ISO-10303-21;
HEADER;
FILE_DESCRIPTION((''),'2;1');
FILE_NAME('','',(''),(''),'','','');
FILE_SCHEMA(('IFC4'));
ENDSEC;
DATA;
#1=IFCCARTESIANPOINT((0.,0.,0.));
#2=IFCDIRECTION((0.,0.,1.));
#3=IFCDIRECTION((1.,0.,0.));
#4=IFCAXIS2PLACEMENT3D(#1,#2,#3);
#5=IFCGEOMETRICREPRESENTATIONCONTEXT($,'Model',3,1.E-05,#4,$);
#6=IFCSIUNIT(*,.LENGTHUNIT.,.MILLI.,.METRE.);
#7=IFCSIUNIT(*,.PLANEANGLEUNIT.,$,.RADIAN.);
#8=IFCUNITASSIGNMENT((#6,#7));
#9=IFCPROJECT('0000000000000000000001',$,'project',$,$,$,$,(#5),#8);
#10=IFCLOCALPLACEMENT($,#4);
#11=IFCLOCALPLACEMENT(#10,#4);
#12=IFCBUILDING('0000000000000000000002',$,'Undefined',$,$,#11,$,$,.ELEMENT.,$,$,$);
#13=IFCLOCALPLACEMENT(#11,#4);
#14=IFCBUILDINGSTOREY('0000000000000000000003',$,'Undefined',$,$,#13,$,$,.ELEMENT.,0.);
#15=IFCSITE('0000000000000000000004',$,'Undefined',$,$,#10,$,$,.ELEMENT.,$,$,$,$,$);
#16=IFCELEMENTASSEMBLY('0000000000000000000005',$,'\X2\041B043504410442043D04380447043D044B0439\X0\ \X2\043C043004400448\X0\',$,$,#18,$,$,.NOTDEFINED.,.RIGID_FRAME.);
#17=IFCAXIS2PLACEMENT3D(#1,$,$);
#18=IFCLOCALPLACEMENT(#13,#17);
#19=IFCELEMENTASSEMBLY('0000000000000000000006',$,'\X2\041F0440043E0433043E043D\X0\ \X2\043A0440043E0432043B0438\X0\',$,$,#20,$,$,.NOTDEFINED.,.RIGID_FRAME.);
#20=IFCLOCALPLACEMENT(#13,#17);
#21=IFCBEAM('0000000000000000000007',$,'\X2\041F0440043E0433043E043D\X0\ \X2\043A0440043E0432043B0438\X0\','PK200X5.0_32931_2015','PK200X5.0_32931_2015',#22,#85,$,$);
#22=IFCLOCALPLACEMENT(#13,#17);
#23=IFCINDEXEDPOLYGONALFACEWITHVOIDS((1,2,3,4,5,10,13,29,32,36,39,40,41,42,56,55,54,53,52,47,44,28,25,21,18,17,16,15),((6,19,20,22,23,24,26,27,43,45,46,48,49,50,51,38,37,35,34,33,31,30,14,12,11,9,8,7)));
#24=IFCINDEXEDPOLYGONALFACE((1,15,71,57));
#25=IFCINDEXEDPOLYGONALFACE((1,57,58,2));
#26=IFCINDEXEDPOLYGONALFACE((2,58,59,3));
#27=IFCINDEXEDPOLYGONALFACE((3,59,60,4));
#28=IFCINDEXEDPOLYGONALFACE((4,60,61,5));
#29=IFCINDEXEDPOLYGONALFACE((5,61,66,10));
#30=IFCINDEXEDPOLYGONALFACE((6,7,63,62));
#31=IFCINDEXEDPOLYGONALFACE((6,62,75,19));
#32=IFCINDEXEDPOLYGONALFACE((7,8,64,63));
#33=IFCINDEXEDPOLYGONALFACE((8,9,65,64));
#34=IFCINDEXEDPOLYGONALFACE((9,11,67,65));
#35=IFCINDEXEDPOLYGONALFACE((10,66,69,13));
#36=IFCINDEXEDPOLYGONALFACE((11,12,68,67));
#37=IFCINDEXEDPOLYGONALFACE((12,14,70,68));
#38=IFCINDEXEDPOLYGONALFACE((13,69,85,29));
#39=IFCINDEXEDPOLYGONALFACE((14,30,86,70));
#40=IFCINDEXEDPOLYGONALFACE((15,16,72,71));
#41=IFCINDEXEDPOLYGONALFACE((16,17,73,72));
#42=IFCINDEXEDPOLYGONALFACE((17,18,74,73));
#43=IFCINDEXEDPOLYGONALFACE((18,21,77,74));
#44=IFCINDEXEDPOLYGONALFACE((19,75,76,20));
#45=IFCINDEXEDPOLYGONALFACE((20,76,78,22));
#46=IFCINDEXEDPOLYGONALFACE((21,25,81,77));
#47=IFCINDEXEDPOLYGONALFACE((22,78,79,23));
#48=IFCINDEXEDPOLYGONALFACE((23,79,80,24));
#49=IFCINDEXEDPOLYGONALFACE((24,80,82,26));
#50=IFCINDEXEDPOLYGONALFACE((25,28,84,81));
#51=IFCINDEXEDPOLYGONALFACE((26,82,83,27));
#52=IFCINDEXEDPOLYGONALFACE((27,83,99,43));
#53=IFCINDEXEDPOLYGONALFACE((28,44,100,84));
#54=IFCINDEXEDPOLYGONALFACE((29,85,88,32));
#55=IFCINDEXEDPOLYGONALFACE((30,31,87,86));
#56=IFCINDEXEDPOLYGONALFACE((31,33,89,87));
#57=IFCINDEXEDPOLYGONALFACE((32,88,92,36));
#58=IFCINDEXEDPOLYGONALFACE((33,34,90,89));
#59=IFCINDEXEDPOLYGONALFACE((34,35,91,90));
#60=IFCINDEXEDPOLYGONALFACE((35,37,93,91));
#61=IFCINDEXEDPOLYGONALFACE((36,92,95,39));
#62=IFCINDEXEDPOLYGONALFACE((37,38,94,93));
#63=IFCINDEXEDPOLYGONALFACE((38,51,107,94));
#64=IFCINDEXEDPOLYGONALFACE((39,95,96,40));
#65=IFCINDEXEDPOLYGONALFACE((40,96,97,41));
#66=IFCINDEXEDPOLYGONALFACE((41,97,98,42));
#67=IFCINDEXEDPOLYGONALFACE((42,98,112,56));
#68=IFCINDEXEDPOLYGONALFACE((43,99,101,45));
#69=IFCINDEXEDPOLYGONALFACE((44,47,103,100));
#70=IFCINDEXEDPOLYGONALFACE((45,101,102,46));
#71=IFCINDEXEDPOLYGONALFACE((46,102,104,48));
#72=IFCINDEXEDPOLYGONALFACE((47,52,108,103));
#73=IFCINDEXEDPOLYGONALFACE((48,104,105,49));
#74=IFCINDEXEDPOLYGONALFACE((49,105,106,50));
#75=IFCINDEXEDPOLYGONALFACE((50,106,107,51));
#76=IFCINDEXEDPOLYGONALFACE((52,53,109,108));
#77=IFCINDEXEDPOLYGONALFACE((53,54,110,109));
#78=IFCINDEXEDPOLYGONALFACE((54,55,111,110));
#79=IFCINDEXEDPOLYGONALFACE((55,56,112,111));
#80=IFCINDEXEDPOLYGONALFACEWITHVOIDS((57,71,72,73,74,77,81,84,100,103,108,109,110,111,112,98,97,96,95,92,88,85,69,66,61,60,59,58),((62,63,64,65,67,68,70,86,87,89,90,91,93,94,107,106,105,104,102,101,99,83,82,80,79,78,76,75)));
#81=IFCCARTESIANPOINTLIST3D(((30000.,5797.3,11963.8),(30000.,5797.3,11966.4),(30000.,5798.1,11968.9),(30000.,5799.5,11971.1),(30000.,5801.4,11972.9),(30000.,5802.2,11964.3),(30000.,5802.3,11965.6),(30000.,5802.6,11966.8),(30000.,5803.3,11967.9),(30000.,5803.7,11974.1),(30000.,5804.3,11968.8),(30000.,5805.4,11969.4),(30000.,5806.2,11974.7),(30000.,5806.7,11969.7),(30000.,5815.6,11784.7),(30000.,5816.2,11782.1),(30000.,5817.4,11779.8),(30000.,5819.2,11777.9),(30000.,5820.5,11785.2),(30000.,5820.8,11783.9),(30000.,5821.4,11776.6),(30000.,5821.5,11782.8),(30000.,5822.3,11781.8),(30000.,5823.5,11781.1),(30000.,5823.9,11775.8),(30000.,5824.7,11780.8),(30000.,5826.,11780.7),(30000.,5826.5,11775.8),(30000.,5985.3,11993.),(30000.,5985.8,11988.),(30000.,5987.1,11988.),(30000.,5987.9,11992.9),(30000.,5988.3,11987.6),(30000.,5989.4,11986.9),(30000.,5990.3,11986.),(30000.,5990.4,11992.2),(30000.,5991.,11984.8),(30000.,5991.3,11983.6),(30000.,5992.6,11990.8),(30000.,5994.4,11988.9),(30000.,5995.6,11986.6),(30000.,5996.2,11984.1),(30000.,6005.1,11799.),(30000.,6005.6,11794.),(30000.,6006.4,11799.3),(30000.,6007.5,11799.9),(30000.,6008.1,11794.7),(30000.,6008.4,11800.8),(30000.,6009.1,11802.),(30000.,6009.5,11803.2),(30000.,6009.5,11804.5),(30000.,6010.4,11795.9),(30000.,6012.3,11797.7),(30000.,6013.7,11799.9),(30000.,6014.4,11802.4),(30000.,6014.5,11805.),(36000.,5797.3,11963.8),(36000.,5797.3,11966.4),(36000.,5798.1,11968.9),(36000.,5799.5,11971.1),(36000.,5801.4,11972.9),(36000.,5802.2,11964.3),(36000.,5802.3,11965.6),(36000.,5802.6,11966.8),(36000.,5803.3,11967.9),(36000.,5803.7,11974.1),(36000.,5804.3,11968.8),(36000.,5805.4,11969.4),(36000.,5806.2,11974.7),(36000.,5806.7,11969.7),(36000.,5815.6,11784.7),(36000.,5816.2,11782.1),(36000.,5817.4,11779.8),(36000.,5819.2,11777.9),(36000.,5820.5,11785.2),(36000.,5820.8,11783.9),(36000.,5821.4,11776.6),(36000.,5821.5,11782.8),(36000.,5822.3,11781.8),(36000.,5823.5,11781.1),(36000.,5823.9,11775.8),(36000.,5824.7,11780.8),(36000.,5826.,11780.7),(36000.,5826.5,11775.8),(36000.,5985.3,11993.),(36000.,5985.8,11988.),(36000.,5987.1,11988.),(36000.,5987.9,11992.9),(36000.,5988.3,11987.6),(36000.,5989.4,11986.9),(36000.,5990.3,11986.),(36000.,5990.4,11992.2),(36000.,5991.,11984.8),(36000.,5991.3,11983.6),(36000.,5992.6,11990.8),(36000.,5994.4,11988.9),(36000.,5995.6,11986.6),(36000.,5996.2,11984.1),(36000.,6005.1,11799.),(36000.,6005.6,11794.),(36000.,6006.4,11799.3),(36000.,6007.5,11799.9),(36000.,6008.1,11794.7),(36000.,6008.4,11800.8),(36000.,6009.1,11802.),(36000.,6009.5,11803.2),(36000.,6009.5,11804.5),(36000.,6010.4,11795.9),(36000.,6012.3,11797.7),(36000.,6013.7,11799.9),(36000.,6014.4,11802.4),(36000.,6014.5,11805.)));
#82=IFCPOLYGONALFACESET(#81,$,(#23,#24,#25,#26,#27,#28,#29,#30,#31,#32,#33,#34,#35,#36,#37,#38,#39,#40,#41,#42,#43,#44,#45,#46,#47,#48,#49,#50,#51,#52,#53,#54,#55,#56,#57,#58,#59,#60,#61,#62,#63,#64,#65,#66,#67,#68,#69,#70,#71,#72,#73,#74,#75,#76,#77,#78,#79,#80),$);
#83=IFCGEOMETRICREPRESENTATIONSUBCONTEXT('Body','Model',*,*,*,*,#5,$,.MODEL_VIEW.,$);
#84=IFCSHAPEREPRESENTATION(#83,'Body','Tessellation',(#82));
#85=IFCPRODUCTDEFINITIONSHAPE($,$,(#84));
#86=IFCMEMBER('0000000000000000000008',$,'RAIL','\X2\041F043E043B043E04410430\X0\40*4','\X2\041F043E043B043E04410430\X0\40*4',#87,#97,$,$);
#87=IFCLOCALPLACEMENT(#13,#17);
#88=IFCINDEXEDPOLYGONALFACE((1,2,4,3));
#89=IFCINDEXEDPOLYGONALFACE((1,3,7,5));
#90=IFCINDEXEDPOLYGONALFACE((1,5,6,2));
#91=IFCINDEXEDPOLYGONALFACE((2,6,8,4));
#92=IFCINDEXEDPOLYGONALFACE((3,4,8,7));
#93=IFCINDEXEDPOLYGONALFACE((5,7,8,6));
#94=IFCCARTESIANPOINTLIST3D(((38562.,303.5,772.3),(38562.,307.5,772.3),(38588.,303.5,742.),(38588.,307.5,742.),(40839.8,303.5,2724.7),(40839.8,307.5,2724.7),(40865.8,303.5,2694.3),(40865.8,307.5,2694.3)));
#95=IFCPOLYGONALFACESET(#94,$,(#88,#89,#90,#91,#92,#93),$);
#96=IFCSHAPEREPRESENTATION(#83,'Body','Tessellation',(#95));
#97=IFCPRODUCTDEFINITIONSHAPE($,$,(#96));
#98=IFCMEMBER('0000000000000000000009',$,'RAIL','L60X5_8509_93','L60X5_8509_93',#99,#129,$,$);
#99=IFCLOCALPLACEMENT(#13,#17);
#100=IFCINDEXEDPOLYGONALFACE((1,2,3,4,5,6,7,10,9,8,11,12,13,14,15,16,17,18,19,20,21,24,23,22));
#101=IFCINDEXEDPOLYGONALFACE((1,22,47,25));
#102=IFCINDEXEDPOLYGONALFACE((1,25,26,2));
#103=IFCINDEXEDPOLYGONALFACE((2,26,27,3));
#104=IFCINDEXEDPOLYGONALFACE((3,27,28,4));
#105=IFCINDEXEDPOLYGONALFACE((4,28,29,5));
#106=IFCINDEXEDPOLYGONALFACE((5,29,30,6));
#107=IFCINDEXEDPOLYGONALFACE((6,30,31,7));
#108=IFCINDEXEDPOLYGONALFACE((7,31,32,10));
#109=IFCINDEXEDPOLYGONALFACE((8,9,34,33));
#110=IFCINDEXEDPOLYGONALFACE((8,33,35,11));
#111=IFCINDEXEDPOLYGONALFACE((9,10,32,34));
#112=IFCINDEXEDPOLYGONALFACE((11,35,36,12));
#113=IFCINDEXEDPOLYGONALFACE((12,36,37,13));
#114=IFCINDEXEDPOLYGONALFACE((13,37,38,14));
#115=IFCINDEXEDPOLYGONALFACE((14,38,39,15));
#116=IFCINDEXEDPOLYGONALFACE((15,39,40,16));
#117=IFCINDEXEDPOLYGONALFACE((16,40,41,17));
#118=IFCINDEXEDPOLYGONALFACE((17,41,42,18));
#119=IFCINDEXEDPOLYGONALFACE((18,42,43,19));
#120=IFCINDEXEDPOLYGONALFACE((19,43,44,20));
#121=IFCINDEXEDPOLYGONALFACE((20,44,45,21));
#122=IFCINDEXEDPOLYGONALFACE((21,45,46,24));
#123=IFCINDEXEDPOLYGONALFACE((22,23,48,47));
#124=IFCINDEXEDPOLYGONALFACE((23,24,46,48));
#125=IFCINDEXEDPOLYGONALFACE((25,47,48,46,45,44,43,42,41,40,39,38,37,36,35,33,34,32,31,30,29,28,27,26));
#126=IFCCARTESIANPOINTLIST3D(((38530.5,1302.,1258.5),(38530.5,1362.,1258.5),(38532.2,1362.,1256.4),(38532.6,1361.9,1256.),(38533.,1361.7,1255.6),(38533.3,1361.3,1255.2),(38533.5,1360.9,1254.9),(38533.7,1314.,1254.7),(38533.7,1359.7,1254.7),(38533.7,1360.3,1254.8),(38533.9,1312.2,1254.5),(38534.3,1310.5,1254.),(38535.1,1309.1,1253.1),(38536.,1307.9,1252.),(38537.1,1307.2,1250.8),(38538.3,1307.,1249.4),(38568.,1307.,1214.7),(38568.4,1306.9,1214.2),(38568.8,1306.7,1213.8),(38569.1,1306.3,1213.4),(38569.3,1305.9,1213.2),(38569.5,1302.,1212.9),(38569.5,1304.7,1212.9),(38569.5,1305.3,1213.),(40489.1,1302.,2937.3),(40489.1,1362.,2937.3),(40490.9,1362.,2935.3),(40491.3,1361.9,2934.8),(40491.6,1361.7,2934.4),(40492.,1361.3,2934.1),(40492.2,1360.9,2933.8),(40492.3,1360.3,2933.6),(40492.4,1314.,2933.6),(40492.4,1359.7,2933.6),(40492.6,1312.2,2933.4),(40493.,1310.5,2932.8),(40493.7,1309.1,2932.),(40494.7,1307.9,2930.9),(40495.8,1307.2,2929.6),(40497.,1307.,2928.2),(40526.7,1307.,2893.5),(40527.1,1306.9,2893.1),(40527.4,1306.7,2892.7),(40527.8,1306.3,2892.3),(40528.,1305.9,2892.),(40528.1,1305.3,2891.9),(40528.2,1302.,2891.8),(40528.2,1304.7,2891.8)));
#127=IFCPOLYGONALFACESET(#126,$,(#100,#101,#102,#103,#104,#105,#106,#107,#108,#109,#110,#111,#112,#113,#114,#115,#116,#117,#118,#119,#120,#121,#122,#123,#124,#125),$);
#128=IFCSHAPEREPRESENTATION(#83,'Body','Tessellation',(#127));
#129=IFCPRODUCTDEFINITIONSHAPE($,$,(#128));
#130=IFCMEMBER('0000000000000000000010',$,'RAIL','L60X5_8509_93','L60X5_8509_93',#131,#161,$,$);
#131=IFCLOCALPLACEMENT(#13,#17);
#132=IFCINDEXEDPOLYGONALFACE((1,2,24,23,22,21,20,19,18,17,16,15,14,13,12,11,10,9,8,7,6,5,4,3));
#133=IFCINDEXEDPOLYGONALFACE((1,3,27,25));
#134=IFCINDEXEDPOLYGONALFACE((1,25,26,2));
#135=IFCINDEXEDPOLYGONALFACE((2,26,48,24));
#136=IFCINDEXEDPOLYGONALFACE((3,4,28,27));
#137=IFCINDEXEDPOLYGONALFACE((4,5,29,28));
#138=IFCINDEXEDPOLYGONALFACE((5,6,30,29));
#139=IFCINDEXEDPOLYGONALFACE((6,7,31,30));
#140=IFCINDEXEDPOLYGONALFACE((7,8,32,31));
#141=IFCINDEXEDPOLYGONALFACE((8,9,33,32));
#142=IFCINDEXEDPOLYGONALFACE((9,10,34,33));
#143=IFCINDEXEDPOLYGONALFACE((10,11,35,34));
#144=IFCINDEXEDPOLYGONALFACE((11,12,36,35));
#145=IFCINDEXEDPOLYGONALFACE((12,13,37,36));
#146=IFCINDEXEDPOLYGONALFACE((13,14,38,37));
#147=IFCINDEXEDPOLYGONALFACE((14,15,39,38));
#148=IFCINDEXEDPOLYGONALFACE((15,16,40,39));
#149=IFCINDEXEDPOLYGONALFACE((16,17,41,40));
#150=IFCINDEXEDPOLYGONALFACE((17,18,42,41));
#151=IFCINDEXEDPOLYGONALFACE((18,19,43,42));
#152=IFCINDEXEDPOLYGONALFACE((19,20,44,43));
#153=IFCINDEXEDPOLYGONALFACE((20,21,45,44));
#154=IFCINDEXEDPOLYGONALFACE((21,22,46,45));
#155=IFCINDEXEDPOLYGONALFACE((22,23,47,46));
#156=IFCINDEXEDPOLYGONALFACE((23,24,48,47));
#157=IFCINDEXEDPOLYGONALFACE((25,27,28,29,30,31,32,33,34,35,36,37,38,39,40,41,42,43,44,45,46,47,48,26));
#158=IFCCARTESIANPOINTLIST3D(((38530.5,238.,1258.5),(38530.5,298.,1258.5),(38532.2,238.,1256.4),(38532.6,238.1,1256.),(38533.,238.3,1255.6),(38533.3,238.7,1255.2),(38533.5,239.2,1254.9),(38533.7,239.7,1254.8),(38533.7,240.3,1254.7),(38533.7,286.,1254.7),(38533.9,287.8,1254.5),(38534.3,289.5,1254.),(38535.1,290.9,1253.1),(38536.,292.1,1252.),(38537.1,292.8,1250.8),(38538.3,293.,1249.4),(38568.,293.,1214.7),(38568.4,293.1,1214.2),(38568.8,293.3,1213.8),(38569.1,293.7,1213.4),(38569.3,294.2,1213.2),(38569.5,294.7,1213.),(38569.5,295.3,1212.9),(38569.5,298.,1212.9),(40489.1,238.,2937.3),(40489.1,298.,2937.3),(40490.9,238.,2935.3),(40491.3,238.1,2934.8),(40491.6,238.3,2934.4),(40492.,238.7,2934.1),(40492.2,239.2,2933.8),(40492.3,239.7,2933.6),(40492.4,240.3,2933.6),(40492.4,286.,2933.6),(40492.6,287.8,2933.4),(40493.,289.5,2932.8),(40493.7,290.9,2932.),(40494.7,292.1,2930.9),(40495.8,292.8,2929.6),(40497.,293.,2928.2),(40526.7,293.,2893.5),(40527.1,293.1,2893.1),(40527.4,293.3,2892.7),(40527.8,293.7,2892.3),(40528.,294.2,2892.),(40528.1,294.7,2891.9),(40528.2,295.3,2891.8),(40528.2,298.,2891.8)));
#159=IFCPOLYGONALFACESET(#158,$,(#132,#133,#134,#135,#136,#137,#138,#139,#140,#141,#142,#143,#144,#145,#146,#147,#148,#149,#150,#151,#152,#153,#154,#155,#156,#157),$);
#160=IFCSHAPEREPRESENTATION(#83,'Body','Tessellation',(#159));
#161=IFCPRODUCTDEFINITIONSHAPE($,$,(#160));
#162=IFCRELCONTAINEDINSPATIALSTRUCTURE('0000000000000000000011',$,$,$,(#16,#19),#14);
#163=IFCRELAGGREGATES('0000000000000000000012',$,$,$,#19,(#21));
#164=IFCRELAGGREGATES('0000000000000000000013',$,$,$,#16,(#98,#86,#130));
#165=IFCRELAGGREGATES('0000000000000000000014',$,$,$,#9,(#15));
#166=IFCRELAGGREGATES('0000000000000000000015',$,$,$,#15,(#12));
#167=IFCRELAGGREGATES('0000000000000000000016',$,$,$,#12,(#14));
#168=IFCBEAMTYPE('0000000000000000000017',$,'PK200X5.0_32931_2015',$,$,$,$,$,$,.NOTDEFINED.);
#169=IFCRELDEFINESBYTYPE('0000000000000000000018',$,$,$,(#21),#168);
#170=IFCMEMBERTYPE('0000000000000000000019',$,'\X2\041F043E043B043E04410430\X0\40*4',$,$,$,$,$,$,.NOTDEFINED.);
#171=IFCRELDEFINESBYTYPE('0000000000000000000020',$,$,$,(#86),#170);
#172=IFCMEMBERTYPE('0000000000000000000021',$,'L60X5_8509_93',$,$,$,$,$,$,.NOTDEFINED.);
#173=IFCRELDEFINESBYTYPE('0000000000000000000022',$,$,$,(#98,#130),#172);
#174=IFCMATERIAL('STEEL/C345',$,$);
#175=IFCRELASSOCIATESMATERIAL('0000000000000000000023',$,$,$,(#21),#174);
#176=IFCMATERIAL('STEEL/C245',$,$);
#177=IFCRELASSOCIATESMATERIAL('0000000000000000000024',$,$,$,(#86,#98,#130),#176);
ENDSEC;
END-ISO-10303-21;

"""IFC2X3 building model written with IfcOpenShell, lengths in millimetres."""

from ifc_helpers import new_model, si_unit, frame, origin_with_axes, origin_2d_with_axis, place, context, subcontext, project, spatial, rectangle, hollow_rectangle, l_section, extrude, material, type_object, element, aggregate, save


model = new_model("IFC2X3")

# Units and contexts
model_context = context("Model", 3, precision=1e-05, world=origin_with_axes())
body_context = subcontext(model_context, "Body", "Model", "MODEL_VIEW")
ifc_project = project(units=[si_unit("LENGTHUNIT", "METRE", prefix="MILLI"), si_unit("PLANEANGLEUNIT", "RADIAN")], contexts=[model_context])

# Site, building, storey
site_placement = place(None, origin_with_axes())
site = spatial("IfcSite", under=ifc_project, at=site_placement, Name="Undefined", CompositionType="ELEMENT")
building_placement = place(site_placement, origin_with_axes())
building = spatial("IfcBuilding", under=site, at=building_placement, Name="Undefined", CompositionType="ELEMENT")
storey_placement = place(building_placement, origin_with_axes())
storey = spatial("IfcBuildingStorey", under=building, at=storey_placement, Name="Undefined", CompositionType="ELEMENT", Elevation=0.0)

# Shared definitions
ifc_material_1 = material(Name="STEEL/C245")

# Element assembly
assembly_1_placement = place(storey_placement, origin_with_axes())
assembly_1 = element("IfcElementAssembly", 1, at=assembly_1_placement, inside=storey, Name="Лестничный марш", AssemblyPlace="NOTDEFINED", PredefinedType="RIGID_FRAME")

# Element assembly, beam
ifc_material_2 = material(Name="STEEL/C345")
beam_type_1 = type_object("IfcBeamType", Name="PK200X5.0_32931_2015", PredefinedType="NOTDEFINED")
assembly_2_placement = place(storey_placement, origin_with_axes())
assembly_2 = element("IfcElementAssembly", 2, at=assembly_2_placement, inside=storey, Name="Прогон кровли", AssemblyPlace="NOTDEFINED", PredefinedType="RIGID_FRAME")
beam_1_placement = place(assembly_2_placement, frame((36000.0, 5905.9, 11884.4), z_axis=(0.0, -0.101645, 0.994821), x_axis=(-1.0, 0.0, 0.0)))
beam_1 = element("IfcBeam", 3, at=beam_1_placement, type_object=beam_type_1, material=ifc_material_2, Name="Прогон кровли", Description="PK200X5.0_32931_2015", ObjectType="PK200X5.0_32931_2015", context=body_context, shape_type="SweptSolid", body=[
    extrude(hollow_rectangle(XDim=200.0, YDim=200.0, WallThickness=5.0, InnerFilletRadius=5.0, OuterFilletRadius=10.0, at=origin_2d_with_axis()), frame((6000.0, 0.0, 0.0), z_axis=(-1.0, 0.0, 0.0), x_axis=(0.0, -1.0, 0.0)), (0.0, 0.0, 1.0), 6000.0),
])
aggregate(assembly_2, [beam_1])

# Members
member_type_1 = type_object("IfcMemberType", Name="Полоса40*4", PredefinedType="NOTDEFINED")
member_1_placement = place(assembly_1_placement, frame((38575.0, 305.5, 757.1), z_axis=(0.650791, 0.0, -0.759257), x_axis=(0.759257, 0.0, 0.650791)))
member_1 = element("IfcMember", 4, at=member_1_placement, type_object=member_type_1, material=ifc_material_1, Name="RAIL", Description="Полоса40*4", ObjectType="Полоса40*4", context=body_context, shape_type="SweptSolid", body=[
    extrude(rectangle(XDim=4.0, YDim=40.0, at=origin_2d_with_axis()), frame((3000.0, 0.0, 0.0), z_axis=(-1.0, 0.0, 0.0), x_axis=(0.0, -1.0, 0.0)), (0.0, 0.0, 1.0), 3000.0),
])
member_type_2 = type_object("IfcMemberType", Name="L60X5_8509_93", PredefinedType="NOTDEFINED")
member_2_placement = place(assembly_1_placement, frame((38550.0, 1332.0, 1235.7), z_axis=(0.650791, 0.0, -0.759257), x_axis=(0.759257, 0.0, 0.650791)))
member_2 = element("IfcMember", 5, at=member_2_placement, type_object=member_type_2, material=ifc_material_1, Name="RAIL", Description="L60X5_8509_93", ObjectType="L60X5_8509_93", context=body_context, shape_type="SweptSolid", body=[
    extrude(l_section(Depth=60.0, Width=60.0, Thickness=5.0, FilletRadius=7.0, EdgeRadius=2.3, at=origin_2d_with_axis()), frame((2579.7, 0.0, 0.0), z_axis=(-1.0, 0.0, 0.0), x_axis=(0.0, -1.0, 0.0)), (0.0, 0.0, 1.0), 2579.7),
])
member_3_placement = place(assembly_1_placement, frame((38550.0, 268.0, 1235.7), z_axis=(0.0, -1.0, 0.0), x_axis=(0.759257, 0.0, 0.650791)))
member_3 = element("IfcMember", 6, at=member_3_placement, type_object=member_type_2, material=ifc_material_1, Name="RAIL", Description="L60X5_8509_93", ObjectType="L60X5_8509_93", context=body_context, shape_type="SweptSolid", body=[
    extrude(l_section(Depth=60.0, Width=60.0, Thickness=5.0, FilletRadius=7.0, EdgeRadius=2.3, at=origin_2d_with_axis()), frame((2579.7, 0.0, 0.0), z_axis=(-1.0, 0.0, 0.0), x_axis=(0.0, -1.0, 0.0)), (0.0, 0.0, 1.0), 2579.7),
])
aggregate(assembly_1, [member_2, member_1, member_3])

save(model, "model.ifc")
